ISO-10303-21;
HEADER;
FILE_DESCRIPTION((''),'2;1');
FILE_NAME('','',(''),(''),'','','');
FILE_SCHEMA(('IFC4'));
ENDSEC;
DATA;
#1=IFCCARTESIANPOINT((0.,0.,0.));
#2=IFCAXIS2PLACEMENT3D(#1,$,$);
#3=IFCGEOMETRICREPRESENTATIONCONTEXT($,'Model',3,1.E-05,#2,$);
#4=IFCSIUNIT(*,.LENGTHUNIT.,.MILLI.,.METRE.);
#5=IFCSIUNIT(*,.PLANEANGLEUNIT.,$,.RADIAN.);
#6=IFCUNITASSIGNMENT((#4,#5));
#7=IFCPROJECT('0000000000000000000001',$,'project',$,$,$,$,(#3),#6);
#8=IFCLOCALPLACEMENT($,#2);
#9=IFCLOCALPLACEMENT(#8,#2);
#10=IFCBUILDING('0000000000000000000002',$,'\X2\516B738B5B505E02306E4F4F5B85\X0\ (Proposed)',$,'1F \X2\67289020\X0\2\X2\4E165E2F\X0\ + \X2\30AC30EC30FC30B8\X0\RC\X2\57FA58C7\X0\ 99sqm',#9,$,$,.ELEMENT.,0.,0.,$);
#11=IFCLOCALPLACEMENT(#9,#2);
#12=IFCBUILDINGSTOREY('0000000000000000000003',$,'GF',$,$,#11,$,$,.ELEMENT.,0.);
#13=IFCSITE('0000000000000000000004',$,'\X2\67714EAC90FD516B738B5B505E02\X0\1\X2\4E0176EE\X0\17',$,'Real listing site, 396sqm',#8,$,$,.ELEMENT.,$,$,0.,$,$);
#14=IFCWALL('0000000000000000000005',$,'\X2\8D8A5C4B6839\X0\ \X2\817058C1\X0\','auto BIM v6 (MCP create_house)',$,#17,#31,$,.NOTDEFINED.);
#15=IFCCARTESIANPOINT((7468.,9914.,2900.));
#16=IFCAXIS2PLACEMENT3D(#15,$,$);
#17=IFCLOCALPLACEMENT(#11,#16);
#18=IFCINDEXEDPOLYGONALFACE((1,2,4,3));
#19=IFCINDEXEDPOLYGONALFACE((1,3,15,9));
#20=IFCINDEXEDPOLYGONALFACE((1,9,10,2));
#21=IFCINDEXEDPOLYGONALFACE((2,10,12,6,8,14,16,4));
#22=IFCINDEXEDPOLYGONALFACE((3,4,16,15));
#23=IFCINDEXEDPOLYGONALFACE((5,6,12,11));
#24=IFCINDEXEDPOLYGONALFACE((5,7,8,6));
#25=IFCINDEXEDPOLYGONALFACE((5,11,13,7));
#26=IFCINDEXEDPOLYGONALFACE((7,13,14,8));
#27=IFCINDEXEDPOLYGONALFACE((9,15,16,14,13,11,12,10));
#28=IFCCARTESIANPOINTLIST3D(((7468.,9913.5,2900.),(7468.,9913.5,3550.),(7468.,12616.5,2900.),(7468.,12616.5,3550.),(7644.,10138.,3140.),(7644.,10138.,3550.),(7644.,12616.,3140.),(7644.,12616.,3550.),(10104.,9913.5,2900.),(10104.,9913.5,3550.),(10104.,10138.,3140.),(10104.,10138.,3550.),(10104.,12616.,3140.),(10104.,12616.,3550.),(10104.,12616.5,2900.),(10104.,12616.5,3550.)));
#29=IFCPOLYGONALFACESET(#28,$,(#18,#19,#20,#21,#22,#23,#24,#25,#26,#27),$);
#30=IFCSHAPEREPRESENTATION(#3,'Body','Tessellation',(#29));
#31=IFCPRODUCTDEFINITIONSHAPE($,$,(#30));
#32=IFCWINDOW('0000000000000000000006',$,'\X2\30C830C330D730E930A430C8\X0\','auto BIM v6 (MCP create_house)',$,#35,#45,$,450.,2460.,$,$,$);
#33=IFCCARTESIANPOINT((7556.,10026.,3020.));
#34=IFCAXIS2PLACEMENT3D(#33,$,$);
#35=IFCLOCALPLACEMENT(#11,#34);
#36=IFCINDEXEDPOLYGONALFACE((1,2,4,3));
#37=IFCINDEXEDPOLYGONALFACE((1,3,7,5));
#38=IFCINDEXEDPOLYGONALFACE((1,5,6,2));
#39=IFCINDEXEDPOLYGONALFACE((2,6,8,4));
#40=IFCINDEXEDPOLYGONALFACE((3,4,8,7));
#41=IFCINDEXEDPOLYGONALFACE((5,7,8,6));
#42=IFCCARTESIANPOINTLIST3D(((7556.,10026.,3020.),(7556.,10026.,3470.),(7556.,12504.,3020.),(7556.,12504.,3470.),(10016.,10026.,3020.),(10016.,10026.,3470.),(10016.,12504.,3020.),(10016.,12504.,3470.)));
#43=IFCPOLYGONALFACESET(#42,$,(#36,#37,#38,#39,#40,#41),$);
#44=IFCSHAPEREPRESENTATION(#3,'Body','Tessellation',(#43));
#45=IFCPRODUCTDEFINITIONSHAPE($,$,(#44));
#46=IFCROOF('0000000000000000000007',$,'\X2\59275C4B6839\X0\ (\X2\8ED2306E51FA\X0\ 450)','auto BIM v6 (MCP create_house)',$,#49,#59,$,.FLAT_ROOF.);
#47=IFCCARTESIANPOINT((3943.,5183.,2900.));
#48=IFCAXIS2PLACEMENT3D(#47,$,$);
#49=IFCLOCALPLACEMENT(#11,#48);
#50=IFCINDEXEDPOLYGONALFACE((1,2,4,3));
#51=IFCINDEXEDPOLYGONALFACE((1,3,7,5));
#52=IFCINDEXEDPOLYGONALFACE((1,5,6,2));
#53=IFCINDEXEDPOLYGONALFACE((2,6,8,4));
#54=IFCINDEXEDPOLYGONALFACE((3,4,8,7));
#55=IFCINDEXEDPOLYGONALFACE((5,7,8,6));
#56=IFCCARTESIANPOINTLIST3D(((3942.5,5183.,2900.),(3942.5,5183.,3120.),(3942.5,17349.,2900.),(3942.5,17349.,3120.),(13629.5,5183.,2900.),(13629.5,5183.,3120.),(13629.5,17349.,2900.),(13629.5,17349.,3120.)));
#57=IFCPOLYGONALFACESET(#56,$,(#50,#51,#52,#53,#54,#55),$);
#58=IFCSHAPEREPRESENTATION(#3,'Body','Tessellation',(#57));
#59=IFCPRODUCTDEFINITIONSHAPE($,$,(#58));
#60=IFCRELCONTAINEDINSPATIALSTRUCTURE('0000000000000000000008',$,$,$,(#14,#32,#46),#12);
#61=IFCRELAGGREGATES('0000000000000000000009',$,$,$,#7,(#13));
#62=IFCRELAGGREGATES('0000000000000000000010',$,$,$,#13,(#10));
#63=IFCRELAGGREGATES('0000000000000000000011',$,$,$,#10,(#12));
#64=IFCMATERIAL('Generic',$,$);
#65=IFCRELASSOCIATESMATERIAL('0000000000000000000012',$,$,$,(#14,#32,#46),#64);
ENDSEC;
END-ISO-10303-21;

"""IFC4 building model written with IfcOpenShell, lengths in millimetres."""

from ifc_helpers import new_model, si_unit, frame, frame_2d, origin, place, context, project, spatial, rectangle, extrude, material, element, fill, save


model = new_model("IFC4")

# Units and contexts
model_context = context("Model", 3, precision=1e-05, world=origin())
ifc_project = project(units=[si_unit("LENGTHUNIT", "METRE", prefix="MILLI"), si_unit("PLANEANGLEUNIT", "RADIAN")], contexts=[model_context])

# Site, building, storey
site_placement = place(None, origin())
site = spatial("IfcSite", under=ifc_project, at=site_placement, Name="東京都八王子市1丁目17", ObjectType="Real listing site, 396sqm", CompositionType="ELEMENT", RefElevation=0.0)
building_placement = place(site_placement, origin())
building = spatial("IfcBuilding", under=site, at=building_placement, Name="八王子市の住宅 (Proposed)", ObjectType="1F 木造2世帯 + ガレージRC基壇 99sqm", CompositionType="ELEMENT", ElevationOfRefHeight=0.0, ElevationOfTerrain=0.0)
storey_placement = place(building_placement, origin())
storey = spatial("IfcBuildingStorey", under=building, at=storey_placement, Name="GF", CompositionType="ELEMENT", Elevation=0.0)

# Shared definitions
ifc_material = material(Name="Generic")

# Wall, opening, window
wall_1_placement = place(storey_placement, frame((7468.0, 9914.0, 2900.0)))
wall_1 = element("IfcWall", 1, at=wall_1_placement, inside=storey, material=ifc_material, Name="越屋根 腰壁", Description="auto BIM v6 (MCP create_house)", PredefinedType="NOTDEFINED", context=model_context, shape_type="SweptSolid", body=[
    extrude(rectangle(XDim=2636.0, YDim=2703.0, at=frame_2d((1318.0, 1351.0))), frame((7468.0, 9914.0, 2900.0)), (0.0, 0.0, 1.0), 650.0),
])
opening_1_placement = place(storey_placement, frame((7556.0, 10026.0, 3020.0)))
opening_1 = element("IfcOpeningElement", 2, at=opening_1_placement, cuts=wall_1, PredefinedType="NOTDEFINED", context=model_context, shape_type="SweptSolid", body=[
    extrude(rectangle(XDim=2460.0, YDim=2478.0, at=frame_2d((1230.0, 1239.0))), frame((7556.0, 10026.0, 3020.0)), (0.0, 0.0, 1.0), 450.0),
])
window_1_placement = place(storey_placement, frame((7556.0, 10026.0, 3020.0)))
window_1 = element("IfcWindow", 3, at=window_1_placement, inside=storey, material=ifc_material, Name="トップライト", Description="auto BIM v6 (MCP create_house)", OverallHeight=450.0, OverallWidth=2460.0, context=model_context, shape_type="SweptSolid", body=[
    extrude(rectangle(XDim=2460.0, YDim=2478.0, at=frame_2d((1230.0, 1239.0))), frame((7556.0, 10026.0, 3020.0)), (0.0, 0.0, 1.0), 450.0),
])
fill(opening_1, window_1)

# Roof
roof_1_placement = place(storey_placement, frame((3943.0, 5183.0, 2900.0)))
element("IfcRoof", 4, at=roof_1_placement, inside=storey, material=ifc_material, Name="大屋根 (軒の出 450)", Description="auto BIM v6 (MCP create_house)", PredefinedType="FLAT_ROOF", context=model_context, shape_type="SweptSolid", body=[
    extrude(rectangle(XDim=9687.0, YDim=12166.0, at=frame_2d((4843.0, 6083.0))), frame((3943.0, 5183.0, 2900.0)), (0.0, 0.0, 1.0), 220.0),
])

save(model, "model.ifc")
